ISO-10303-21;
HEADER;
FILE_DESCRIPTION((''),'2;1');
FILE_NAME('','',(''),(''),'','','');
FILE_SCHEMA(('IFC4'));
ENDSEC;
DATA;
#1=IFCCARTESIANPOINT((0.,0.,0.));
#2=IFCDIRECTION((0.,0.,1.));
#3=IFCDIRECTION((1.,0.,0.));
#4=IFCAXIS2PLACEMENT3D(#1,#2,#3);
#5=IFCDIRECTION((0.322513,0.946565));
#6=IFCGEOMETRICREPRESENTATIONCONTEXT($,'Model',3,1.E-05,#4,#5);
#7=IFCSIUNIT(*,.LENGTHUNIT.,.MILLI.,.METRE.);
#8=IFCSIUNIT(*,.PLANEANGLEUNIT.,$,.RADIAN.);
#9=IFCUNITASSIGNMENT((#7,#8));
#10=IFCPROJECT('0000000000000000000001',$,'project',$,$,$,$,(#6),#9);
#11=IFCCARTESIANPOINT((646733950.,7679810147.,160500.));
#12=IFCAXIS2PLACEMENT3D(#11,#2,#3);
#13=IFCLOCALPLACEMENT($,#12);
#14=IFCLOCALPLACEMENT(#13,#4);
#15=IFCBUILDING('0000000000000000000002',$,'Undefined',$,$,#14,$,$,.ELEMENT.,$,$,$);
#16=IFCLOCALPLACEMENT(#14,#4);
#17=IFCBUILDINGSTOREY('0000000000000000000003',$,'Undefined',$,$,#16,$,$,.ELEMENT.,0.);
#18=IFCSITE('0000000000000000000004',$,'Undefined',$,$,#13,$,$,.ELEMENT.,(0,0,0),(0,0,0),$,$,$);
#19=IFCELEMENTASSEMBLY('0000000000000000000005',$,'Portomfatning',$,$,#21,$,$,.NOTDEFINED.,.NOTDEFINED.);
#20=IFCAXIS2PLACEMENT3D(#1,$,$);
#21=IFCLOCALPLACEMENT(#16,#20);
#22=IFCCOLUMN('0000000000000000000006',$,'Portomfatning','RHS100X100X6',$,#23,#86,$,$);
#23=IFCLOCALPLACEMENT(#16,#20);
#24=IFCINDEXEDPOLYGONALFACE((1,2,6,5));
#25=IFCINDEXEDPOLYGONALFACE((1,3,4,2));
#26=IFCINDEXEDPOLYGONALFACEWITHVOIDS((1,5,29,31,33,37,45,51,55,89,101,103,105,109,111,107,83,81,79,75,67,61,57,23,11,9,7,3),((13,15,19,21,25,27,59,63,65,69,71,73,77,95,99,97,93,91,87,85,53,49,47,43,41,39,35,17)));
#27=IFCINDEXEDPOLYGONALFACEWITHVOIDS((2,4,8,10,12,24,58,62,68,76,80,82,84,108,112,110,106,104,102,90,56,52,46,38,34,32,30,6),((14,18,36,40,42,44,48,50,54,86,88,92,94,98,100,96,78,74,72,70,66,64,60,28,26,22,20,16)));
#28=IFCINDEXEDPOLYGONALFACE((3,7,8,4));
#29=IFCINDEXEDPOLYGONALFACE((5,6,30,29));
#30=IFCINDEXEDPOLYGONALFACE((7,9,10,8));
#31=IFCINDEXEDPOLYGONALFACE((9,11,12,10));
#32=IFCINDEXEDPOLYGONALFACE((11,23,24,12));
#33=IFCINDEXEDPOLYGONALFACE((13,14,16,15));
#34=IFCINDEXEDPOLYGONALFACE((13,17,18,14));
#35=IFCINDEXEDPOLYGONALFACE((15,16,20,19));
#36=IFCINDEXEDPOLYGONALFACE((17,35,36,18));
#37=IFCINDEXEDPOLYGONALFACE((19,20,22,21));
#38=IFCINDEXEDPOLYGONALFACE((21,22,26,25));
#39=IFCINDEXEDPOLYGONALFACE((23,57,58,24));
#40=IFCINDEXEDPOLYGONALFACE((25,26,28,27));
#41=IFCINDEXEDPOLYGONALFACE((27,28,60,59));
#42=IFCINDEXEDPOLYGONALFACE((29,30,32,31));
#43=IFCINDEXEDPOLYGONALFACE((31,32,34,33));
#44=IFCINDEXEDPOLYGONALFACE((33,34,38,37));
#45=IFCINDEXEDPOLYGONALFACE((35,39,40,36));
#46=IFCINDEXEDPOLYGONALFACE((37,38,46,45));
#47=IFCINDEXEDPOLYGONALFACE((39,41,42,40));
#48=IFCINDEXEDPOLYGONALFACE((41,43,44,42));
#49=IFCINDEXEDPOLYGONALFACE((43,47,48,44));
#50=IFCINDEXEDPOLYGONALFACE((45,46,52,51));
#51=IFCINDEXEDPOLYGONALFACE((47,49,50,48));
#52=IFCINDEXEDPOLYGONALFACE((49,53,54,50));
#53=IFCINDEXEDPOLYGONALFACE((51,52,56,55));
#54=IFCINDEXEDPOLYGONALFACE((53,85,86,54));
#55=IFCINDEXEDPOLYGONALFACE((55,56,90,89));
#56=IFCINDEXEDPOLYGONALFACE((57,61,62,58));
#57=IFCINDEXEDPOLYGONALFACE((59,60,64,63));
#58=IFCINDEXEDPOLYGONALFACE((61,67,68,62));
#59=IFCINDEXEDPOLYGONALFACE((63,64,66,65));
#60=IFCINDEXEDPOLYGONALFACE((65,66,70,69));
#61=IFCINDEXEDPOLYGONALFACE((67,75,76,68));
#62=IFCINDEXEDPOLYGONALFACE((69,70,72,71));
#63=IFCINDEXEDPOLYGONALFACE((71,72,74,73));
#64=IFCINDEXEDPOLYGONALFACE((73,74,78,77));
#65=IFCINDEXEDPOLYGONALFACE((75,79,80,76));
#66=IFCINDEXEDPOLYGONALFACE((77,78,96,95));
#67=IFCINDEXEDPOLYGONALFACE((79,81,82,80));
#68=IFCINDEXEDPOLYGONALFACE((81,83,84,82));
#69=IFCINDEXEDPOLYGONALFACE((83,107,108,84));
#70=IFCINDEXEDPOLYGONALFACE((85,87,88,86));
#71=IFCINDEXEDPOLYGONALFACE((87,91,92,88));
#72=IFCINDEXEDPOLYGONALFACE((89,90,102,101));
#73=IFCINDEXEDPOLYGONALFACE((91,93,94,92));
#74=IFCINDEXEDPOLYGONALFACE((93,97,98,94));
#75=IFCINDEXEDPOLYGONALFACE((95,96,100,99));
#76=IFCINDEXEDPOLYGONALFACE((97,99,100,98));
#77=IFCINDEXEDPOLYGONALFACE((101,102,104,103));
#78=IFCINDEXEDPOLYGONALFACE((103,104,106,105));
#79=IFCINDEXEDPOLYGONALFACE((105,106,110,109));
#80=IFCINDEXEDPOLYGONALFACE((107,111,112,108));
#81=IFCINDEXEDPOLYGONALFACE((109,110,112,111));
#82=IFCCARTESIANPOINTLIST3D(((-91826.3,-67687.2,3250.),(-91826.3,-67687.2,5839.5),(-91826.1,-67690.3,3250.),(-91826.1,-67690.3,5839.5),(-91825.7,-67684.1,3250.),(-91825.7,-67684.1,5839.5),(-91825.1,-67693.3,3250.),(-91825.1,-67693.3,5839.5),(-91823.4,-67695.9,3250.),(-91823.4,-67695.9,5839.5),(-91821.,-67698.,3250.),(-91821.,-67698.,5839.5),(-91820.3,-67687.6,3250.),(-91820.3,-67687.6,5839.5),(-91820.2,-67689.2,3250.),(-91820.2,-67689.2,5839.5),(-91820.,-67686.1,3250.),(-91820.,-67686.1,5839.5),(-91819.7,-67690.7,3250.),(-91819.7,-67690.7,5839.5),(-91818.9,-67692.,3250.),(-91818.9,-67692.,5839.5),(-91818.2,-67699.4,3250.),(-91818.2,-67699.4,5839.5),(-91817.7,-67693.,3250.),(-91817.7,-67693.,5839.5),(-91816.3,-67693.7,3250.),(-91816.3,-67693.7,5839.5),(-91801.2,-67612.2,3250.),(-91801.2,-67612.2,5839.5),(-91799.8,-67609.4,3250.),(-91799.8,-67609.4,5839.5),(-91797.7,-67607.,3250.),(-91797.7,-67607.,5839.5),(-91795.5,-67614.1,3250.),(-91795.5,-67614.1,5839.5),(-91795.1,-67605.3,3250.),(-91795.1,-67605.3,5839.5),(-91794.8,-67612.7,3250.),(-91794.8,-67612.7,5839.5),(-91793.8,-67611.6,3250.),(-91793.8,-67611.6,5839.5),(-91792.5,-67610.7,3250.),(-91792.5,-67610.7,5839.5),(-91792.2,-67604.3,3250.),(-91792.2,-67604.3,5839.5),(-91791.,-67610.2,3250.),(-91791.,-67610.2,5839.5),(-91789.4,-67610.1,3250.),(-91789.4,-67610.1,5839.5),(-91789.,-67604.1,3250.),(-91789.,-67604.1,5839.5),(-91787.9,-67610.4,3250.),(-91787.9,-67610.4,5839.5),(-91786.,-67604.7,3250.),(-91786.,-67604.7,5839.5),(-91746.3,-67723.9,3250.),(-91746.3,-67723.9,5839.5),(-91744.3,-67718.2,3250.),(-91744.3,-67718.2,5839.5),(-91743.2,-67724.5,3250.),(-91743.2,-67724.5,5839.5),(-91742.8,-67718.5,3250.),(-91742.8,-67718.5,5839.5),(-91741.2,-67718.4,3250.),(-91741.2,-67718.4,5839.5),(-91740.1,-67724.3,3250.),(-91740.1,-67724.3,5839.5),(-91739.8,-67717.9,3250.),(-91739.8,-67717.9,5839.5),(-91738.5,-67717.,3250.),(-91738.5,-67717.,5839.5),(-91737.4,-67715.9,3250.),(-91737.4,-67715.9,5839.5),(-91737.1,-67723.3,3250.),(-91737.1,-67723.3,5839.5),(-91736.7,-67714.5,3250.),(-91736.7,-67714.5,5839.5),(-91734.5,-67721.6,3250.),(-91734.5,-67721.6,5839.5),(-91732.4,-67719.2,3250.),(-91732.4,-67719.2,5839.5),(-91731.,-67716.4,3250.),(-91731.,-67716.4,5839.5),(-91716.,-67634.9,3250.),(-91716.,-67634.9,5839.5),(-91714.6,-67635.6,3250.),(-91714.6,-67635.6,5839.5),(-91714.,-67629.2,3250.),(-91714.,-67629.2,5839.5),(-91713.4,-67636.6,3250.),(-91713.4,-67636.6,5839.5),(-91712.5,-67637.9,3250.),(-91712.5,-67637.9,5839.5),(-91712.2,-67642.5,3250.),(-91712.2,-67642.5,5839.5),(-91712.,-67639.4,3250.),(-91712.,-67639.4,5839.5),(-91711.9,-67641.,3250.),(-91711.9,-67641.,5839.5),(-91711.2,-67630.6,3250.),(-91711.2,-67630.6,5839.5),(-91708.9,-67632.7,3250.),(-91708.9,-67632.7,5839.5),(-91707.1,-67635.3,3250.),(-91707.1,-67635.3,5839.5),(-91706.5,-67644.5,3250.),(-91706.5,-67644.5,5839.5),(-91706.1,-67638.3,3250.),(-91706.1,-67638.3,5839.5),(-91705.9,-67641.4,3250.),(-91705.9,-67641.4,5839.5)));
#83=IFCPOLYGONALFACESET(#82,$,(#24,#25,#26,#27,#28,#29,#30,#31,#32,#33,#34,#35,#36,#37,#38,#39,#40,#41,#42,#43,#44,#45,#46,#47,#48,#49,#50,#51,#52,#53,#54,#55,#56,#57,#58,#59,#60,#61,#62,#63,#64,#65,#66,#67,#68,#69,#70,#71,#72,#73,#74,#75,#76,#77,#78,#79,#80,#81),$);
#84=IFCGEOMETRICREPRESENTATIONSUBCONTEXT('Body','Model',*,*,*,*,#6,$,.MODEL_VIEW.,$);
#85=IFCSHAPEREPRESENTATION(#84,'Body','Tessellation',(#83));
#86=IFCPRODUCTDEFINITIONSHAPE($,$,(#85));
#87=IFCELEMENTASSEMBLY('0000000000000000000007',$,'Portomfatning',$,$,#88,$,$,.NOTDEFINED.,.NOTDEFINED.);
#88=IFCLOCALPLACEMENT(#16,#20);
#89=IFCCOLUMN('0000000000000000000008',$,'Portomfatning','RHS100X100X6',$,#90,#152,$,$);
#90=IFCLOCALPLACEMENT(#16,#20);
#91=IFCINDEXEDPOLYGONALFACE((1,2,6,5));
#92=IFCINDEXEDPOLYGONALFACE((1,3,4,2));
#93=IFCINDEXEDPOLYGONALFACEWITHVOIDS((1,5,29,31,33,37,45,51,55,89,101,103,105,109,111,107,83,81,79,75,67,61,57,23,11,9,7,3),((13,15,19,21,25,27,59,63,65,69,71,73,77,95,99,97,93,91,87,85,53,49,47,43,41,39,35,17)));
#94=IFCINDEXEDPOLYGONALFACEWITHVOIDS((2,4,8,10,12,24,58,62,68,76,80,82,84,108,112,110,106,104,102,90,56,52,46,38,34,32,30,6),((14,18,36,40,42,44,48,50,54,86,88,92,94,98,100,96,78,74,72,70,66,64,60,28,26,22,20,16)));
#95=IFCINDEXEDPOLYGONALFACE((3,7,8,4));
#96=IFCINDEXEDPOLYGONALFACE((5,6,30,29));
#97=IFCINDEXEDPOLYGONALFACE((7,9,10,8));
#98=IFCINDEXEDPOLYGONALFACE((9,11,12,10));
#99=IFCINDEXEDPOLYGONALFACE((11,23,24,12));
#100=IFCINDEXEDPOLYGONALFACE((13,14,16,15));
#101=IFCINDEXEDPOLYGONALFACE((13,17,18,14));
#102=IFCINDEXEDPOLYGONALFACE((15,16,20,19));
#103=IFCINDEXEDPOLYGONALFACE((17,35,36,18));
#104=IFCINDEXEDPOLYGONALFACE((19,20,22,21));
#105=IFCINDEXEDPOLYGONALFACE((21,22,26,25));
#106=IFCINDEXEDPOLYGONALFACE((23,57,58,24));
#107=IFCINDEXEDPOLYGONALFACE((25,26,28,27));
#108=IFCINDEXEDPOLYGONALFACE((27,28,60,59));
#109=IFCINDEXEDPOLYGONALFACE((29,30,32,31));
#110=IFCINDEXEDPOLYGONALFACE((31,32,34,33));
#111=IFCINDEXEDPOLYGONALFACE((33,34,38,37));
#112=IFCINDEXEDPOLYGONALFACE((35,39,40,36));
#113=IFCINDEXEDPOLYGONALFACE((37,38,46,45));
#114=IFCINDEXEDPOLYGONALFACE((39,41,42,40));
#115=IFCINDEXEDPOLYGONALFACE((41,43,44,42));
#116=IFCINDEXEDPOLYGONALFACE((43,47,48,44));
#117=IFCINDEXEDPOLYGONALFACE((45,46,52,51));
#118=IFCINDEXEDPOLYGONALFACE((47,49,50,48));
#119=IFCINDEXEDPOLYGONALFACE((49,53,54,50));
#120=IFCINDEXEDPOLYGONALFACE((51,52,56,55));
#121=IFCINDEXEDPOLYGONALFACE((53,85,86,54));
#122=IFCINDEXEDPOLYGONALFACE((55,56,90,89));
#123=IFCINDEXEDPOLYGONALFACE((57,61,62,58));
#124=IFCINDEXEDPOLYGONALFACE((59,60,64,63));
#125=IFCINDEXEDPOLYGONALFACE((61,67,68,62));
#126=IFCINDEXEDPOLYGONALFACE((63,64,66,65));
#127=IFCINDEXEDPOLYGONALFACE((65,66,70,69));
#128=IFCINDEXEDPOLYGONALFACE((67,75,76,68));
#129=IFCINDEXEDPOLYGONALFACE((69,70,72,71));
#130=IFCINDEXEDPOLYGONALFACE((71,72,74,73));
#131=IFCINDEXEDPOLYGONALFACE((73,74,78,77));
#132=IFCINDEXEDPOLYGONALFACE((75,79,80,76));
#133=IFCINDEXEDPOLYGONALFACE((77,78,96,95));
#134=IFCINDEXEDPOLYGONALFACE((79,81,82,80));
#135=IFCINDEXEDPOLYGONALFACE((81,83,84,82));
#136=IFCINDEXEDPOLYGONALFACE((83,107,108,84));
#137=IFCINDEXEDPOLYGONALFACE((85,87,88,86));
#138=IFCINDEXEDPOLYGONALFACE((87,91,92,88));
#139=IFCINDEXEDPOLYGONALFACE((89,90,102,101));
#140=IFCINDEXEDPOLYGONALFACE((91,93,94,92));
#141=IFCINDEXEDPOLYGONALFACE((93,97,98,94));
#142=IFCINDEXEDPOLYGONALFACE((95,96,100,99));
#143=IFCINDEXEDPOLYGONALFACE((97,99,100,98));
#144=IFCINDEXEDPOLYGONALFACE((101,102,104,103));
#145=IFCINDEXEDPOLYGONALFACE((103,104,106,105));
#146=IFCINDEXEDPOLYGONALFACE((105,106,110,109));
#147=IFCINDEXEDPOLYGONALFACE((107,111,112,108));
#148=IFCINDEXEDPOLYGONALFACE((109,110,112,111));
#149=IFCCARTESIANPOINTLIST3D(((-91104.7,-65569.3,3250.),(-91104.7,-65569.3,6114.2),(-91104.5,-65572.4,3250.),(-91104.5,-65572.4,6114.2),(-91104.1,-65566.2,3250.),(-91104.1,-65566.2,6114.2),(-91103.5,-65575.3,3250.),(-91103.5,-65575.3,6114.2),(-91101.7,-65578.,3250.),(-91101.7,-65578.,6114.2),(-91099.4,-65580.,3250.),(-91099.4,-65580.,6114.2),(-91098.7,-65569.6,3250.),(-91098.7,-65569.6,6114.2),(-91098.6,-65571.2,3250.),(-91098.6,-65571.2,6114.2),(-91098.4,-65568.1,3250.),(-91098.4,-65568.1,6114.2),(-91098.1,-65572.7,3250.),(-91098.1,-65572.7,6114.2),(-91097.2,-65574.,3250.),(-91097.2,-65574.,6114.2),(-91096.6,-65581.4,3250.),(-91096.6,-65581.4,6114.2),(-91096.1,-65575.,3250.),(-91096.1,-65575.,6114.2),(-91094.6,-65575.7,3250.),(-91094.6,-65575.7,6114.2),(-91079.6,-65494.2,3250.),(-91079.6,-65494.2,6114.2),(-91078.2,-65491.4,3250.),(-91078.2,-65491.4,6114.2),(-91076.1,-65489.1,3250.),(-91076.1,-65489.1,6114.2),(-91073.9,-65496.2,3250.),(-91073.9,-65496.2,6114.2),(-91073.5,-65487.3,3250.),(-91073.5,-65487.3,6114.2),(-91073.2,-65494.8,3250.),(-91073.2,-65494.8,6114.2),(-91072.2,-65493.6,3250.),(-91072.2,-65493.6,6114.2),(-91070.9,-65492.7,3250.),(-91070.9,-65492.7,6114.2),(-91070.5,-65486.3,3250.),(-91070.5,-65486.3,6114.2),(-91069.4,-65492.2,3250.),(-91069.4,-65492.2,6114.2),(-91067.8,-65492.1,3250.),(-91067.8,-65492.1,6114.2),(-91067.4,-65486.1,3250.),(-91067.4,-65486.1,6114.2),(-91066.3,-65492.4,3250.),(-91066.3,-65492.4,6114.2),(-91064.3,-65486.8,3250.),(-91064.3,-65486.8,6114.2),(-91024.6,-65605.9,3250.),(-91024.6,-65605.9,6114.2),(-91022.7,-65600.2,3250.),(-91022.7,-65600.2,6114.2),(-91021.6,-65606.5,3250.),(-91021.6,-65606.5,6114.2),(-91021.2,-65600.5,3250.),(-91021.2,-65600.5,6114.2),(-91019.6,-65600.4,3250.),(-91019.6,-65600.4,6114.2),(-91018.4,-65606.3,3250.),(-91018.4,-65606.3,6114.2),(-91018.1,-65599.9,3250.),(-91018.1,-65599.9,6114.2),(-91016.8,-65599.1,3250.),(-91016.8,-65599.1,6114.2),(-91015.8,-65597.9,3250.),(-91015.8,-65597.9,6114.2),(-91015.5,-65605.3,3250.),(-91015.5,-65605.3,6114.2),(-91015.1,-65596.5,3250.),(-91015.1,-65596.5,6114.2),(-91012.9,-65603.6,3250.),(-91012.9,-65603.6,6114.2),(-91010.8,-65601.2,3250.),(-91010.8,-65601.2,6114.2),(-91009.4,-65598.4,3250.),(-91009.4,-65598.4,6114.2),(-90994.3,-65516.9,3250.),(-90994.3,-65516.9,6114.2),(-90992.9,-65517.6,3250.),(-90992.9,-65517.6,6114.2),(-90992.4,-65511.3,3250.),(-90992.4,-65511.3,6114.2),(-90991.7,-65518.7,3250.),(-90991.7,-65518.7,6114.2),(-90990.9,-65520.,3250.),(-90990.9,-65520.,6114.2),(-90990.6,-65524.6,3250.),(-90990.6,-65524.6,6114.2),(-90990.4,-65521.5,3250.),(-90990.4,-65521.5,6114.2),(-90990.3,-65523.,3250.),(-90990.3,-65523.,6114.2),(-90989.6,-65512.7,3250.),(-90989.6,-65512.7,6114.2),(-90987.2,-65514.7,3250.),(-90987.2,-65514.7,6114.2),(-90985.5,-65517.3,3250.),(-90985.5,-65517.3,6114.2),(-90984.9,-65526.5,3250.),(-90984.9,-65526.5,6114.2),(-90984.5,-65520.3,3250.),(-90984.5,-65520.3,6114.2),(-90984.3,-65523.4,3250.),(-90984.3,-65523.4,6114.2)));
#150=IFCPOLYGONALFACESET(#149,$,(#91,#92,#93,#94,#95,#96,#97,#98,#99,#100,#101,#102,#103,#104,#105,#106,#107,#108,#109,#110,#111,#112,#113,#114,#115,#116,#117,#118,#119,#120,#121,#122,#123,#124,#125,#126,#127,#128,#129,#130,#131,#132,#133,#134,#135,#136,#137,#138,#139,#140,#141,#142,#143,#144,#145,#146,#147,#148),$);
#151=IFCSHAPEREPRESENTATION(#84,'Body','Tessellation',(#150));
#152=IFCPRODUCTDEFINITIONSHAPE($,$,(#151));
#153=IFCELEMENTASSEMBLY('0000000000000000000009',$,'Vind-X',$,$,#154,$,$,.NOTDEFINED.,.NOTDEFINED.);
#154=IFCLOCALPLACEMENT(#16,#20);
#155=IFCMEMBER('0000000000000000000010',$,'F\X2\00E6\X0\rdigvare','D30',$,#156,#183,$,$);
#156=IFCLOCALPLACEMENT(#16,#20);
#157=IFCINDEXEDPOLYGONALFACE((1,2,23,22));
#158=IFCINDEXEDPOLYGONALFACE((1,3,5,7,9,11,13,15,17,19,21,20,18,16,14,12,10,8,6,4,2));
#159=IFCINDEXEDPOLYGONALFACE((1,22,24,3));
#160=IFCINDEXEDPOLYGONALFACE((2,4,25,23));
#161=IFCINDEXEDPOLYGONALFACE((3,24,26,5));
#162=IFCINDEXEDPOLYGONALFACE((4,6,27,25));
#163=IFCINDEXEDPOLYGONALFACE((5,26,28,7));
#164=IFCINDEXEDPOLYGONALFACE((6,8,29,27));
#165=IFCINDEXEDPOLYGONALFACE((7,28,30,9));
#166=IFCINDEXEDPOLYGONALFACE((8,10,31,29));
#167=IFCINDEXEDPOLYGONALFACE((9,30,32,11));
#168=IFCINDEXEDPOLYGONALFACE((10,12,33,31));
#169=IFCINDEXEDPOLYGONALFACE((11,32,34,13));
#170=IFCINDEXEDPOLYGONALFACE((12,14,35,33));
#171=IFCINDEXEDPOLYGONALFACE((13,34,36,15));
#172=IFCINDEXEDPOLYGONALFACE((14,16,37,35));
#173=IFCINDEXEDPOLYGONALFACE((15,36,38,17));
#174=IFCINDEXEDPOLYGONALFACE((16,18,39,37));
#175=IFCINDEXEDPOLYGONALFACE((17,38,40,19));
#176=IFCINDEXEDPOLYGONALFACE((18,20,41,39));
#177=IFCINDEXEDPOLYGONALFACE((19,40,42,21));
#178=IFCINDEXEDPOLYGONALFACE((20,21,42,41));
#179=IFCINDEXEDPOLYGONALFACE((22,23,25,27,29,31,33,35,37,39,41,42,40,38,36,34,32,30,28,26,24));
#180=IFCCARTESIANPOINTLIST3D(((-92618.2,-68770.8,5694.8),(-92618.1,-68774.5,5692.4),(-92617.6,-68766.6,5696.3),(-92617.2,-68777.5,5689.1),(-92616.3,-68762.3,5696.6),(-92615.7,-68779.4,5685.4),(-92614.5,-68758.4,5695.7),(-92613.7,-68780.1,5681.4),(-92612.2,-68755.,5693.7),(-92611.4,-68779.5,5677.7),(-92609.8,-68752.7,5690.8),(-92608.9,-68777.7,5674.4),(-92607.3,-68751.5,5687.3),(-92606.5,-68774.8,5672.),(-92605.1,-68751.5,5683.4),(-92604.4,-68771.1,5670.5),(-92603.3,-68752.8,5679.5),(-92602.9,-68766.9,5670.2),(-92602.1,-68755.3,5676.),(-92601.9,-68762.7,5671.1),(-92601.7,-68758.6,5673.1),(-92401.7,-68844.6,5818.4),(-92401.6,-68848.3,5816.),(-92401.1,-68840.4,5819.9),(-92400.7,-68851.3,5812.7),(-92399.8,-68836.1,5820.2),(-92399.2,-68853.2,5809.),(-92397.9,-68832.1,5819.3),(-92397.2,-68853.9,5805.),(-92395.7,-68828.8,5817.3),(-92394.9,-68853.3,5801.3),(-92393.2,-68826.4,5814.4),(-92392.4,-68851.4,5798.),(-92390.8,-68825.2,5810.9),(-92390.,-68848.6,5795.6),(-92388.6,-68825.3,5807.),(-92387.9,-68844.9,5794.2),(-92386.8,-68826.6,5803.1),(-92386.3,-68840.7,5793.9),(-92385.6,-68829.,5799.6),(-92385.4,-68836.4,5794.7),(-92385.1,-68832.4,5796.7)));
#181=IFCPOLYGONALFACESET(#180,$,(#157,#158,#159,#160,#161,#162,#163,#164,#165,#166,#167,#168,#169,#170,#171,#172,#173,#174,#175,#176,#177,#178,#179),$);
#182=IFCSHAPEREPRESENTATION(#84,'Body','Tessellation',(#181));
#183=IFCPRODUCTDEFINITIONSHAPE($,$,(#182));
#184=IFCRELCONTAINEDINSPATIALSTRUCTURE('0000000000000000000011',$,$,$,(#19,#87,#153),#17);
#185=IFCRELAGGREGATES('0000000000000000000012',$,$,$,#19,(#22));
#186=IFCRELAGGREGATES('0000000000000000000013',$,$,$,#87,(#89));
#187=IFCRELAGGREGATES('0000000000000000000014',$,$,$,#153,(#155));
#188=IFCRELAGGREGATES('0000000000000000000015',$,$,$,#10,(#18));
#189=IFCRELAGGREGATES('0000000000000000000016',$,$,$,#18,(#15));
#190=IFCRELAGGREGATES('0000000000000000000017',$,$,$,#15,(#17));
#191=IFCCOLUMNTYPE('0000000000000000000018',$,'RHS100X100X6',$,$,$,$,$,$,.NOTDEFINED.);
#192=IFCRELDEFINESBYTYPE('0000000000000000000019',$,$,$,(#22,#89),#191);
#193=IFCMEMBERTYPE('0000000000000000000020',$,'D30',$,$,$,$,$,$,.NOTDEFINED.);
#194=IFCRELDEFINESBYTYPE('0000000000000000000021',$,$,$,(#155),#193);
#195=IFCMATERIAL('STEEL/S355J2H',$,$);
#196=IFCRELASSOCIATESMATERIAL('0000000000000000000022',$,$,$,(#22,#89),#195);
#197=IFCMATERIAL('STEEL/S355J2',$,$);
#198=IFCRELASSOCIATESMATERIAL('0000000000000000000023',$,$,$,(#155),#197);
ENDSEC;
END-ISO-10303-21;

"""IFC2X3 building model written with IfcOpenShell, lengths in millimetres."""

from ifc_helpers import new_model, si_unit, direction, frame, origin_with_axes, origin_2d_with_axis, place, context, subcontext, project, spatial, hollow_rectangle, circle, extrude, material, type_object, element, aggregate, save


model = new_model("IFC2X3")

# Units and contexts
model_context = context("Model", 3, precision=1e-05, world=origin_with_axes(), true_north=direction((0.322513, 0.946565)))
body_context = subcontext(model_context, "Body", "Model", "MODEL_VIEW")
ifc_project = project(units=[si_unit("LENGTHUNIT", "METRE", prefix="MILLI"), si_unit("PLANEANGLEUNIT", "RADIAN")], contexts=[model_context])

# Site, building, storey
site_placement = place(None, frame((646733950.0, 7679810147.0, 160500.0), z_axis=(0.0, 0.0, 1.0), x_axis=(1.0, 0.0, 0.0)))
site = spatial("IfcSite", under=ifc_project, at=site_placement, Name="Undefined", CompositionType="ELEMENT", RefLatitude=(0, 0, 0), RefLongitude=(0, 0, 0))
building_placement = place(site_placement, origin_with_axes())
building = spatial("IfcBuilding", under=site, at=building_placement, Name="Undefined", CompositionType="ELEMENT")
storey_placement = place(building_placement, origin_with_axes())
storey = spatial("IfcBuildingStorey", under=building, at=storey_placement, Name="Undefined", CompositionType="ELEMENT", Elevation=0.0)

# Element assemblies, columns
assembly_1_placement = place(storey_placement, origin_with_axes())
assembly_1 = element("IfcElementAssembly", 1, at=assembly_1_placement, inside=storey, Name="Portomfatning", AssemblyPlace="NOTDEFINED", PredefinedType="NOTDEFINED")
ifc_material_1 = material(Name="STEEL/S355J2H")
column_type = type_object("IfcColumnType", Name="RHS100X100X6", PredefinedType="NOTDEFINED")
column_1_placement = place(assembly_1_placement, frame((-91766.1, -67664.3, 3250.0), z_axis=(0.0, 0.0, 1.0), x_axis=(-0.322513, -0.946565, 0.0)))
column_1 = element("IfcColumn", 2, at=column_1_placement, type_object=column_type, material=ifc_material_1, Name="Portomfatning", Description="RHS100X100X6", context=body_context, shape_type="SweptSolid", body=[
    extrude(hollow_rectangle(XDim=100.0, YDim=100.0, WallThickness=6.0, InnerFilletRadius=6.0, OuterFilletRadius=12.0, at=origin_2d_with_axis()), frame((0.0, 0.0, 2589.5), z_axis=(0.0, 0.0, -1.0), x_axis=(0.0, 1.0, 0.0)), (0.0, 0.0, 1.0), 2589.5),
])
aggregate(assembly_1, [column_1])
assembly_2_placement = place(storey_placement, origin_with_axes())
assembly_2 = element("IfcElementAssembly", 3, at=assembly_2_placement, inside=storey, Name="Portomfatning", AssemblyPlace="NOTDEFINED", PredefinedType="NOTDEFINED")
column_2_placement = place(assembly_2_placement, frame((-91044.5, -65546.3, 3250.0), z_axis=(0.0, 0.0, 1.0), x_axis=(-0.322513, -0.946565, 0.0)))
column_2 = element("IfcColumn", 4, at=column_2_placement, type_object=column_type, material=ifc_material_1, Name="Portomfatning", Description="RHS100X100X6", context=body_context, shape_type="SweptSolid", body=[
    extrude(hollow_rectangle(XDim=100.0, YDim=100.0, WallThickness=6.0, InnerFilletRadius=6.0, OuterFilletRadius=12.0, at=origin_2d_with_axis()), frame((0.0, 0.0, 2864.2), z_axis=(0.0, 0.0, -1.0), x_axis=(0.0, 1.0, 0.0)), (0.0, 0.0, 1.0), 2864.2),
])
aggregate(assembly_2, [column_2])

# Shared definitions
ifc_material_2 = material(Name="STEEL/S355J2")

# Element assembly, member
assembly_3_placement = place(storey_placement, origin_with_axes())
assembly_3 = element("IfcElementAssembly", 5, at=assembly_3_placement, inside=storey, Name="Vind-X", AssemblyPlace="NOTDEFINED", PredefinedType="NOTDEFINED")
member_type_1 = type_object("IfcMemberType", Name="D30", PredefinedType="NOTDEFINED")
member_1_placement = place(assembly_3_placement, frame((-92393.4, -68839.5, 5807.0), z_axis=(-0.450012, 0.153328, 0.879761), x_axis=(-0.832751, 0.283734, -0.475416)))
member_1 = element("IfcMember", 6, at=member_1_placement, type_object=member_type_1, material=ifc_material_2, Name="Færdigvare", Description="D30", context=body_context, shape_type="SweptSolid", body=[
    extrude(circle(Radius=15.0, at=origin_2d_with_axis()), frame((260.0, 0.0, 0.0), z_axis=(-1.0, 0.0, 0.0), x_axis=(0.0, -1.0, 0.0)), (0.0, 0.0, 1.0), 260.0),
])

aggregate(assembly_3, [member_1])

save(model, "model.ifc")
